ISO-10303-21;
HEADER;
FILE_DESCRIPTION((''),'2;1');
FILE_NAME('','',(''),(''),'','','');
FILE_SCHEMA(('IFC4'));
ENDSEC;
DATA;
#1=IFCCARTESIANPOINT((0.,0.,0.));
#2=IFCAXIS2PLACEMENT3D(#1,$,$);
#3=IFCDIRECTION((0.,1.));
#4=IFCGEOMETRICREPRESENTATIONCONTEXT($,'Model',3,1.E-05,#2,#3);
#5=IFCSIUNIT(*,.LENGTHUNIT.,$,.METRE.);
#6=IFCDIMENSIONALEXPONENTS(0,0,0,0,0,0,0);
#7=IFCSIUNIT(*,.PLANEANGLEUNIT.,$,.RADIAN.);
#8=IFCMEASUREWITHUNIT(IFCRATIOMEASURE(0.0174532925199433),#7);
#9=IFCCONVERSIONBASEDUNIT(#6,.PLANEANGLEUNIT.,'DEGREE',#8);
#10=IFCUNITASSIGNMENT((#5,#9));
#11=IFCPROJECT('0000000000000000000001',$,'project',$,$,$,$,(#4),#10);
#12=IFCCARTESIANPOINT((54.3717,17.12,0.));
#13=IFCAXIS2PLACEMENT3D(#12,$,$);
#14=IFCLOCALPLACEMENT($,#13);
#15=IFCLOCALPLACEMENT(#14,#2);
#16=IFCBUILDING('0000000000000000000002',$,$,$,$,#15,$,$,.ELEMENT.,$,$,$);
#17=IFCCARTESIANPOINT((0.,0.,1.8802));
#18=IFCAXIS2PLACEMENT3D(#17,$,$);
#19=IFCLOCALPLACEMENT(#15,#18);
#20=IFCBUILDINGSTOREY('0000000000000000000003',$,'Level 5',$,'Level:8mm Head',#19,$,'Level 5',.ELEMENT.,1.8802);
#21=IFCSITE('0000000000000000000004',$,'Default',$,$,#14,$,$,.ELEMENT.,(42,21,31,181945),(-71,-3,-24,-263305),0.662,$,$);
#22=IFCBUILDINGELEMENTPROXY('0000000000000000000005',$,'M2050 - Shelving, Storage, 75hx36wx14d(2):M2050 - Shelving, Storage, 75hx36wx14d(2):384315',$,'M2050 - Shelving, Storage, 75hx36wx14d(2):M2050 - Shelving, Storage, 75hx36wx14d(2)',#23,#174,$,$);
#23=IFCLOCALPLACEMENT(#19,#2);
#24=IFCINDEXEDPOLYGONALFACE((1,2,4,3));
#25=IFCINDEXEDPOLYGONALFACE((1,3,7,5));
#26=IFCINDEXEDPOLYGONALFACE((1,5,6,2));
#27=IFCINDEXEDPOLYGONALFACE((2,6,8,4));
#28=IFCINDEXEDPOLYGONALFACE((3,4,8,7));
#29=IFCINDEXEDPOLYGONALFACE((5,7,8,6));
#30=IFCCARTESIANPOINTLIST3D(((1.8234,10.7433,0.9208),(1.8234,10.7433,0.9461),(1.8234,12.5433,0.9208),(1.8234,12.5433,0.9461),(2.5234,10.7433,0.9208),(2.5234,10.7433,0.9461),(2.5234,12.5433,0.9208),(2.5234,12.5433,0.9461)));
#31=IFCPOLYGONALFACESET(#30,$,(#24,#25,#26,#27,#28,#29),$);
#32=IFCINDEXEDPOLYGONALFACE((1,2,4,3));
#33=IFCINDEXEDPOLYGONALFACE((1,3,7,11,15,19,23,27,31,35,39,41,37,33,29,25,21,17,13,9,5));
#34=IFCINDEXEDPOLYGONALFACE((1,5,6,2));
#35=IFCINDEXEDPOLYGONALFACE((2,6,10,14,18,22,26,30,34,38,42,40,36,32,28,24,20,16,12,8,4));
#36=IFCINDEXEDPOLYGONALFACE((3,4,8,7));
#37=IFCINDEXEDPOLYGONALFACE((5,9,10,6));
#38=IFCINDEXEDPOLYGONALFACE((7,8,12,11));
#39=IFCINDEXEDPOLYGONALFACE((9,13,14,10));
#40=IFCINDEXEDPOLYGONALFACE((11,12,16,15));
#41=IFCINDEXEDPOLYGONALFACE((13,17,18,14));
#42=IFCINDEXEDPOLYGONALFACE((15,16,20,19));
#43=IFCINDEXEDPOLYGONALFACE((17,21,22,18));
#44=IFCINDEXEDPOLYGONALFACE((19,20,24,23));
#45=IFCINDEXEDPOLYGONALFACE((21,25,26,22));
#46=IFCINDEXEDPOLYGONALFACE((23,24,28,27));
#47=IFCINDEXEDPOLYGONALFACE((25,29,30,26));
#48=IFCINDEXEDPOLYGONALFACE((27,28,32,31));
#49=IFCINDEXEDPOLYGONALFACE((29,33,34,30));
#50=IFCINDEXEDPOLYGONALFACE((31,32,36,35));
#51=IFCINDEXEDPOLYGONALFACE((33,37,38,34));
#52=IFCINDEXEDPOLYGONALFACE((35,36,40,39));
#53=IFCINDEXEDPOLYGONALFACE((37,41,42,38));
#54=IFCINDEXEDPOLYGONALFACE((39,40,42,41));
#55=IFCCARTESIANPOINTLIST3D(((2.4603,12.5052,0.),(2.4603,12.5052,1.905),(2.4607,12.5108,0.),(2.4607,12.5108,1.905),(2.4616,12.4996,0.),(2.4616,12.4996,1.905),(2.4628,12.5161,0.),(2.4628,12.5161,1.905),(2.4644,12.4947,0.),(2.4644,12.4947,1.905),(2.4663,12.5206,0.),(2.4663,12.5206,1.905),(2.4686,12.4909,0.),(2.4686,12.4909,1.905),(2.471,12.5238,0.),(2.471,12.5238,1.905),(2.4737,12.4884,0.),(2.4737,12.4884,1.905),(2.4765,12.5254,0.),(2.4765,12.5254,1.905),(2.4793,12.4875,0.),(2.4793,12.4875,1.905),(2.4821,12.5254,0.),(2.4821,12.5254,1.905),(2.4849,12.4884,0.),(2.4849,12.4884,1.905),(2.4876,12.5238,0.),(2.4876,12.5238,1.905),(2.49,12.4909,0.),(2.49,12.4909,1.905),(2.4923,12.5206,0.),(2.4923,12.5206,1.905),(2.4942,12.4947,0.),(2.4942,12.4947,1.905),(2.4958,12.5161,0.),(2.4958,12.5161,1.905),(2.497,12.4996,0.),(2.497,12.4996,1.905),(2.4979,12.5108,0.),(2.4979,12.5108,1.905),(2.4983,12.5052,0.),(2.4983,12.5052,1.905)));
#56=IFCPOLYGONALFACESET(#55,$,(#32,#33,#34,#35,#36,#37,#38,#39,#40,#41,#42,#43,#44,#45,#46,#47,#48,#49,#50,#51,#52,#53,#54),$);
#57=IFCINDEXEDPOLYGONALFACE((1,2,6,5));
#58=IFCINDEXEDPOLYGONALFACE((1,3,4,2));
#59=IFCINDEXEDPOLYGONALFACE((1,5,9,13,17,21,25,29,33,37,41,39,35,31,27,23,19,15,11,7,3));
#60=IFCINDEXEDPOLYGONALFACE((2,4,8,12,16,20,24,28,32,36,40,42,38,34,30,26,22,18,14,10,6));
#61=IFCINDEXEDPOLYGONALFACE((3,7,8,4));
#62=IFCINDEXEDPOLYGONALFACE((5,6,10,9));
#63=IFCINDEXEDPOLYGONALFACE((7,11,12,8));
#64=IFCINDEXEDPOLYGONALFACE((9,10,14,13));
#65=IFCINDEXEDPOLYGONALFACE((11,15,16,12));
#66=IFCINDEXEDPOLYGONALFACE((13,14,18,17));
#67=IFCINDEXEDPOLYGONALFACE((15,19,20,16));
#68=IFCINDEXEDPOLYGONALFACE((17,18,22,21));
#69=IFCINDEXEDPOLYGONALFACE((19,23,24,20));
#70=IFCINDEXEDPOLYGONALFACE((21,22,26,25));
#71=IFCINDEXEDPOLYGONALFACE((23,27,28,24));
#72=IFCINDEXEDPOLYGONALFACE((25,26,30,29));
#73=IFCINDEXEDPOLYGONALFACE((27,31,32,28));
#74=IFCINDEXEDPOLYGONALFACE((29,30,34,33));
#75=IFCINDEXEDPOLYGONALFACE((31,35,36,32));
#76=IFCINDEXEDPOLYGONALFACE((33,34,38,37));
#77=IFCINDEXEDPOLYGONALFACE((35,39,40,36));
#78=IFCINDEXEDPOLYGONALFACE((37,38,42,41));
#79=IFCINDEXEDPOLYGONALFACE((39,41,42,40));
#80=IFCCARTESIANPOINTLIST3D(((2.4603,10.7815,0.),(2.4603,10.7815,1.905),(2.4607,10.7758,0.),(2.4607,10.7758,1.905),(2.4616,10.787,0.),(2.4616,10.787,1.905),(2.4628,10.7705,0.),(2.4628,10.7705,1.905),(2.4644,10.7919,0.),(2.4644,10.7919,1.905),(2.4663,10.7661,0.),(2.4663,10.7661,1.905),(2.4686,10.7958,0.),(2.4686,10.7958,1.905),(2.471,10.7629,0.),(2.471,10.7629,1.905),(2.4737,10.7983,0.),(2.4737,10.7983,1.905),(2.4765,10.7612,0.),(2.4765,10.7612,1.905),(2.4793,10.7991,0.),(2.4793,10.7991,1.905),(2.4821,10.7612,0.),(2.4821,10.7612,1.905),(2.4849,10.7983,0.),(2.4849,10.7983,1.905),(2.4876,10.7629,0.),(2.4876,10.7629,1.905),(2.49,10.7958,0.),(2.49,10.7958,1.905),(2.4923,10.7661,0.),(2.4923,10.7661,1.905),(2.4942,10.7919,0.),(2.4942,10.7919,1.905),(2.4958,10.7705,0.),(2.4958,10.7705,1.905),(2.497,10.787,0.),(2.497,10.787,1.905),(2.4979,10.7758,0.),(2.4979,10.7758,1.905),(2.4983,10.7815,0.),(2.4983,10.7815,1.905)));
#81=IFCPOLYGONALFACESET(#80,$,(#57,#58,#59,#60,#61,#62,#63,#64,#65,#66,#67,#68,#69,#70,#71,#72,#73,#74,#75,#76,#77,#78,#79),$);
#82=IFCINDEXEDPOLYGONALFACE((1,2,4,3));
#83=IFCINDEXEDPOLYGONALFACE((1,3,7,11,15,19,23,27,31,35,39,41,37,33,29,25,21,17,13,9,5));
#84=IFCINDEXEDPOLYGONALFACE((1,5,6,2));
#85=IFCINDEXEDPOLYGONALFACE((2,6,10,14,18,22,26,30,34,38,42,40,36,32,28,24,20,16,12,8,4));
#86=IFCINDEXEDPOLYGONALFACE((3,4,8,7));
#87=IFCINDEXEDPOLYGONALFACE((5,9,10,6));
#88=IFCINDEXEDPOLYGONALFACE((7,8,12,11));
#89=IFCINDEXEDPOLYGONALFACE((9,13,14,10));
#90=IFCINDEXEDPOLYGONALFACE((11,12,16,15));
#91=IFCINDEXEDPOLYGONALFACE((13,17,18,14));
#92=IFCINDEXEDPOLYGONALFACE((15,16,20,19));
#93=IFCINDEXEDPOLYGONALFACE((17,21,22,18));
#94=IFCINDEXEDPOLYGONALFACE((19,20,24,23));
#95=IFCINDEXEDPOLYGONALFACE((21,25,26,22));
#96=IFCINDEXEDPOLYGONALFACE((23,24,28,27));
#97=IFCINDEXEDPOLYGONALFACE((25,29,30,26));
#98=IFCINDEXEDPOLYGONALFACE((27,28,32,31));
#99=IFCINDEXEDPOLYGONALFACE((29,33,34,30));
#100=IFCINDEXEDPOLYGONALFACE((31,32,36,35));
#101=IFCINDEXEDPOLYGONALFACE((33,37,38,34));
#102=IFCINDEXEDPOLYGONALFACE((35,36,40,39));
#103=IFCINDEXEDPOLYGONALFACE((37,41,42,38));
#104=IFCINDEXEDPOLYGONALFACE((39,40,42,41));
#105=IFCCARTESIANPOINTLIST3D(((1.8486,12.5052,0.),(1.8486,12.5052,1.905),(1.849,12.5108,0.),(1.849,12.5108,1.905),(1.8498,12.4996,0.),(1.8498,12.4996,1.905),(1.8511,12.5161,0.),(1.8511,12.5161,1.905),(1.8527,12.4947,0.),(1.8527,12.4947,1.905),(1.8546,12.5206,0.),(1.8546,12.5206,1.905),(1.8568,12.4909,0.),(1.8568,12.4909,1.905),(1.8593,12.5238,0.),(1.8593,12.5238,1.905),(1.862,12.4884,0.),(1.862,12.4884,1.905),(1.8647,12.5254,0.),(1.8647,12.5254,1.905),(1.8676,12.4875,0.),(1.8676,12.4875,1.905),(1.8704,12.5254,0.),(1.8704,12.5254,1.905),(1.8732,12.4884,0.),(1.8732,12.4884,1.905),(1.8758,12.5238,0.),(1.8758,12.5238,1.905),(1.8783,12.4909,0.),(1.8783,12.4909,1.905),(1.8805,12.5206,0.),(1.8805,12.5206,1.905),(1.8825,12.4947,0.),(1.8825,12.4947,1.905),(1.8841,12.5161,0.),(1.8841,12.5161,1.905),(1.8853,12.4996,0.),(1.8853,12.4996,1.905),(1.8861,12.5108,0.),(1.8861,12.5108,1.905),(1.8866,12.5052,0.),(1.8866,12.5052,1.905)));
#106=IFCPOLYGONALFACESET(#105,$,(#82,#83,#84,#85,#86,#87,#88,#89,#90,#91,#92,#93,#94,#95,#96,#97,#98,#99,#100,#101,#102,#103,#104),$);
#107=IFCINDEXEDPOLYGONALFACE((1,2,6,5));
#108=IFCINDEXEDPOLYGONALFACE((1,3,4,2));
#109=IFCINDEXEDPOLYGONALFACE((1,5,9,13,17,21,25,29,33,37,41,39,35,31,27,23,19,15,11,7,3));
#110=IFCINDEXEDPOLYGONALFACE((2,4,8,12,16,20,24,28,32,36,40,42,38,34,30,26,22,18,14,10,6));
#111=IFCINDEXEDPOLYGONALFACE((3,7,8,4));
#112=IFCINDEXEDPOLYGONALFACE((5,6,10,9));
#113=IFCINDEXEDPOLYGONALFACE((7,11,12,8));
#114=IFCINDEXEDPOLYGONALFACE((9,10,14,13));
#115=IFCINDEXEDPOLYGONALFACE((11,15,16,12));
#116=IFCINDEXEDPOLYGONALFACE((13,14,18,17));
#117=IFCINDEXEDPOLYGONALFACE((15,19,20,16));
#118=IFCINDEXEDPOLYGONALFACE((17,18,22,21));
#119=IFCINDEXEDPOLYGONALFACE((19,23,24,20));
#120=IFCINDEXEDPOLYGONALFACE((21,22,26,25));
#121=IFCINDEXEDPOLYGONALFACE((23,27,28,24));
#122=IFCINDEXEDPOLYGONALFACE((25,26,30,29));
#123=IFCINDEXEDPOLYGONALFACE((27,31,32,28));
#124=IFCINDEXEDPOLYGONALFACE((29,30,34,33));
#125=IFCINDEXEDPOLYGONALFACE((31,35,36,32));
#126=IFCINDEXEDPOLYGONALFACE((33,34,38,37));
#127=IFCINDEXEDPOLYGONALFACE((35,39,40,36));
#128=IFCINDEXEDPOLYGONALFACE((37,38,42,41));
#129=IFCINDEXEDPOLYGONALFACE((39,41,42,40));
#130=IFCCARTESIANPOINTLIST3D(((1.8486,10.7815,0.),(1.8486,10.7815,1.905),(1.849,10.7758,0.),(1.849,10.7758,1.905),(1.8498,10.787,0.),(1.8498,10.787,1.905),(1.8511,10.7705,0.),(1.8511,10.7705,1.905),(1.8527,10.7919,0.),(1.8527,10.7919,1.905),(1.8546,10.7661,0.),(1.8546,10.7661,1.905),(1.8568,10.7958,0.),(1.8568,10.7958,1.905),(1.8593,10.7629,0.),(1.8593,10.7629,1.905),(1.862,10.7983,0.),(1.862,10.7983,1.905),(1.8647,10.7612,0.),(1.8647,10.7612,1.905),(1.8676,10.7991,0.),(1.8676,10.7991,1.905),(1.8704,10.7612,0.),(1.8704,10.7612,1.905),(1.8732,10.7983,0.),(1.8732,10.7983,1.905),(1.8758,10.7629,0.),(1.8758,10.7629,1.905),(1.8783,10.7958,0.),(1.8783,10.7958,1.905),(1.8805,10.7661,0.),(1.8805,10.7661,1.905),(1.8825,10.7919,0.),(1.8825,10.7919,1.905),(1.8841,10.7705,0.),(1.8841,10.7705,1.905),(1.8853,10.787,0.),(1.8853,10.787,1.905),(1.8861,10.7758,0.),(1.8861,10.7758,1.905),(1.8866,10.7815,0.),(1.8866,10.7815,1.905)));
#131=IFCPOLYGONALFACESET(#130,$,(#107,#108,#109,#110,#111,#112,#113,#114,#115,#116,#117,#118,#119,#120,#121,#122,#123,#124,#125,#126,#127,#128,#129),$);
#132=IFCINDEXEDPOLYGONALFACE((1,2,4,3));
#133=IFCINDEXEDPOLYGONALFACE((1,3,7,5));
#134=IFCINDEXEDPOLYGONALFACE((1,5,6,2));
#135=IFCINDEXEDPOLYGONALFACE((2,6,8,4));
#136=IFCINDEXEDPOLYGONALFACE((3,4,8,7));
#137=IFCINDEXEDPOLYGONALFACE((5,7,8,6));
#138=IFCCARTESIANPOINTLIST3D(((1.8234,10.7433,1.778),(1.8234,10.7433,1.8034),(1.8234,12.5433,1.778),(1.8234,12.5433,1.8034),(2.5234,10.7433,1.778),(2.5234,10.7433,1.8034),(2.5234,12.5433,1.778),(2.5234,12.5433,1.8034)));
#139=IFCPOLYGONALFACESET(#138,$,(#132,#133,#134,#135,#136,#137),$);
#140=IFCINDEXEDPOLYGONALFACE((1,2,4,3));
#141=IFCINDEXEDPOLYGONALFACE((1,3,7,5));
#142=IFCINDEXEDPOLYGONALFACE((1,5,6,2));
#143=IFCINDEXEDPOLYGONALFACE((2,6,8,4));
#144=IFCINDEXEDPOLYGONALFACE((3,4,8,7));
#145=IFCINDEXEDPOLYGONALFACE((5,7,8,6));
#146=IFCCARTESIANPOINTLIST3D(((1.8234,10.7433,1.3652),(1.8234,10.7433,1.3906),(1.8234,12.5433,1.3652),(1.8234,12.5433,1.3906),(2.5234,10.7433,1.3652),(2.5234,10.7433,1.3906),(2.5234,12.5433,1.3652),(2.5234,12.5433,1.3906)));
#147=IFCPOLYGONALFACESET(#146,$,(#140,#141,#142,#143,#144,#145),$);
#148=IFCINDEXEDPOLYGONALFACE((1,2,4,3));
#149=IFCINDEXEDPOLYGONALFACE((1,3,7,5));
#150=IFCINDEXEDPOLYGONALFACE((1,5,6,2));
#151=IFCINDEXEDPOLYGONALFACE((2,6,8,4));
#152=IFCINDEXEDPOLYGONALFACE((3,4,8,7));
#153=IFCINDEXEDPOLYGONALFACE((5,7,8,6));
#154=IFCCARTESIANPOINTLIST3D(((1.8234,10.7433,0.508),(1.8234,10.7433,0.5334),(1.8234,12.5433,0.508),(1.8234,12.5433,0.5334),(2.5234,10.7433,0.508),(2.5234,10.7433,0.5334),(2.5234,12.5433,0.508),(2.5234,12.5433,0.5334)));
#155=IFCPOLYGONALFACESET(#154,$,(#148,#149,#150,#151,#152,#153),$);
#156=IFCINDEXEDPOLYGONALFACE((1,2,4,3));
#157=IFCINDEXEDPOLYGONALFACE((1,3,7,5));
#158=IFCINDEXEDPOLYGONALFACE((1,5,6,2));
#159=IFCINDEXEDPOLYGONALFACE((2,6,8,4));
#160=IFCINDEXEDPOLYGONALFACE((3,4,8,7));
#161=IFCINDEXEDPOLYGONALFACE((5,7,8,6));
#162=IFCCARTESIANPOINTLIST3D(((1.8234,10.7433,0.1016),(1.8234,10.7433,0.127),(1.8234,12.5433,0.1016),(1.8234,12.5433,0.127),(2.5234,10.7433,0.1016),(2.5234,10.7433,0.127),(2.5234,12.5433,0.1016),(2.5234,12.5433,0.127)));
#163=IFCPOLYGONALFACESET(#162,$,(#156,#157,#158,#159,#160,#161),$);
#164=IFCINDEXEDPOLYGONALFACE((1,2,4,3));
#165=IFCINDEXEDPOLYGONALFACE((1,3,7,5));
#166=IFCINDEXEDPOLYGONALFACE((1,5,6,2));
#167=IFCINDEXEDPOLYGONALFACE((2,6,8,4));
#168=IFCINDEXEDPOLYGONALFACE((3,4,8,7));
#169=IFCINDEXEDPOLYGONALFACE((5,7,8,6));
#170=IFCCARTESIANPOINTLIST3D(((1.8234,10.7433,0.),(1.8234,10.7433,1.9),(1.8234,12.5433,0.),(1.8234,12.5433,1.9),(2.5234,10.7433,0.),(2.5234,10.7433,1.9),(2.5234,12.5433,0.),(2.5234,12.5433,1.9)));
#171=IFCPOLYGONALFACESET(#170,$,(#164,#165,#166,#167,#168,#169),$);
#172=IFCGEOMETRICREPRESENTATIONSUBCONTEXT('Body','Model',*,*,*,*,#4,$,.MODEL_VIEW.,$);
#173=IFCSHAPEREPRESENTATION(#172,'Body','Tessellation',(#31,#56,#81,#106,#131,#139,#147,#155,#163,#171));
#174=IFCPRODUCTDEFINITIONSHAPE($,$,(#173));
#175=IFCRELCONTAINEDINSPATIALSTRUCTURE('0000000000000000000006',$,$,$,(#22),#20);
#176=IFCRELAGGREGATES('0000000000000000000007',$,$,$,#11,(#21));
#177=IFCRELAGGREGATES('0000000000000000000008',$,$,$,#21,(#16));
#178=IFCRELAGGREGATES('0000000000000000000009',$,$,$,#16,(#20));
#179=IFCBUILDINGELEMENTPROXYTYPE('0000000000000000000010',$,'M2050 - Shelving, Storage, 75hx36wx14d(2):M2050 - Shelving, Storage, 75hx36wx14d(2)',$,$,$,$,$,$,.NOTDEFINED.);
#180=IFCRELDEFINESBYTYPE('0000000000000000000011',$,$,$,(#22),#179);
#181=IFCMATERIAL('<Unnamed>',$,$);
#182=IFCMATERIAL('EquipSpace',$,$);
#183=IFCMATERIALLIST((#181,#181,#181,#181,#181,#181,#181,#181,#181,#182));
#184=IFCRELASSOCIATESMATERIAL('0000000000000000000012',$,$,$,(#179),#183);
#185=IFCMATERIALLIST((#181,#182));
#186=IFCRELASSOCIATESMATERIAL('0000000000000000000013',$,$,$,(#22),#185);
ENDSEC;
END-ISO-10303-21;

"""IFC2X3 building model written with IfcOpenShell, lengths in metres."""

from ifc_helpers import new_model, entity, si_unit, converted_unit, direction, frame, frame_2d, origin, origin_2d_with_axis, place, context, subcontext, project, spatial, rectangle, circle, extrude, source, transform, mapped, material, material_list, type_object, type_shapes, element, save


model = new_model("IFC2X3")

# Units and contexts
model_context = context("Model", 3, precision=1e-05, world=origin(), true_north=direction((0.0, 1.0)))
body_context = subcontext(model_context, "Body", "Model", "MODEL_VIEW")
ifc_project = project(units=[si_unit("LENGTHUNIT", "METRE"), converted_unit("PLANEANGLEUNIT", "DEGREE", entity("IfcRatioMeasure", 0.0174532925199433), si_unit("PLANEANGLEUNIT", "RADIAN"), dimensions=[0, 0, 0, 0, 0, 0, 0])], contexts=[model_context])

# Site, building, storey
site_placement = place(None, frame((54.3717, 17.12, 0.0)))
site = spatial("IfcSite", under=ifc_project, at=site_placement, Name="Default", CompositionType="ELEMENT", RefLatitude=(42, 21, 31, 181945), RefLongitude=(-71, -3, -24, -263305), RefElevation=0.662)
building_placement = place(site_placement, origin())
building = spatial("IfcBuilding", under=site, at=building_placement, CompositionType="ELEMENT")
storey_placement = place(building_placement, frame((0.0, 0.0, 1.8802)))
storey = spatial("IfcBuildingStorey", under=building, at=storey_placement, Name="Level 5", ObjectType="Level:8mm Head", LongName="Level 5", CompositionType="ELEMENT", Elevation=1.8802)

# Building element proxy
ifc_material_1 = material(Name="<Unnamed>")
ifc_material_2 = material(Name="EquipSpace")
ifc_material_list_1 = material_list([ifc_material_1, ifc_material_1, ifc_material_1, ifc_material_1, ifc_material_1, ifc_material_1, ifc_material_1, ifc_material_1, ifc_material_1, ifc_material_2])
building_element_proxy_type = type_object("IfcBuildingElementProxyType", Name="M2050 - Shelving, Storage, 75hx36wx14d(2):M2050 - Shelving, Storage, 75hx36wx14d(2)", PredefinedType="NOTDEFINED", material=ifc_material_list_1)
shared_shape = source(origin(), body_context, "Body", "SweptSolid", [
    extrude(rectangle(XDim=1.8, YDim=0.7, at=origin_2d_with_axis()), frame((0.0, 0.0, 0.9207), z_axis=(0.0, 0.0, 1.0), x_axis=(-1.0, 0.0, 0.0)), (0.0, 0.0, 1.0), 0.0254),
    extrude(circle(Radius=0.0191, at=origin_2d_with_axis()), frame((0.8633, -0.3059, 0.0), z_axis=(0.0, 0.0, 1.0), x_axis=(-1.0, 0.0, 0.0)), (0.0, 0.0, 1.0), 1.905),
    extrude(circle(Radius=0.0191, at=origin_2d_with_axis()), frame((-0.8633, -0.3059, 0.0)), (0.0, 0.0, 1.0), 1.905),
    extrude(circle(Radius=0.0191, at=origin_2d_with_axis()), frame((0.8633, 0.3059, 0.0), z_axis=(0.0, 0.0, 1.0), x_axis=(-1.0, 0.0, 0.0)), (0.0, 0.0, 1.0), 1.905),
    extrude(circle(Radius=0.0191, at=origin_2d_with_axis()), frame((-0.8633, 0.3059, 0.0)), (0.0, 0.0, 1.0), 1.905),
    extrude(rectangle(XDim=1.8, YDim=0.7, at=origin_2d_with_axis()), frame((0.0, 0.0, 1.778), z_axis=(0.0, 0.0, 1.0), x_axis=(-1.0, 0.0, 0.0)), (0.0, 0.0, 1.0), 0.0254),
    extrude(rectangle(XDim=1.8, YDim=0.7, at=origin_2d_with_axis()), frame((0.0, 0.0, 1.3653), z_axis=(0.0, 0.0, 1.0), x_axis=(-1.0, 0.0, 0.0)), (0.0, 0.0, 1.0), 0.0254),
    extrude(rectangle(XDim=1.8, YDim=0.7, at=origin_2d_with_axis()), frame((0.0, 0.0, 0.508), z_axis=(0.0, 0.0, 1.0), x_axis=(-1.0, 0.0, 0.0)), (0.0, 0.0, 1.0), 0.0254),
    extrude(rectangle(XDim=1.8, YDim=0.7, at=origin_2d_with_axis()), frame((0.0, 0.0, 0.1016), z_axis=(0.0, 0.0, 1.0), x_axis=(-1.0, 0.0, 0.0)), (0.0, 0.0, 1.0), 0.0254),
    extrude(rectangle(XDim=0.7, YDim=1.8, at=frame_2d((0.0, 0.18), x_axis=(1.0, 0.0))), frame((-0.18, 0.0, 0.0), z_axis=(0.0, 0.0, 1.0), x_axis=(0.0, -1.0, 0.0)), (0.0, 0.0, 1.0), 1.9),
])
type_shapes(building_element_proxy_type, [shared_shape])
ifc_material_list_2 = material_list([ifc_material_1, ifc_material_2])
proxy_1_placement = place(storey_placement, frame((2.1734, 11.6433, 0.0), z_axis=(0.0, 0.0, 1.0), x_axis=(0.0, 1.0, 0.0)))
element("IfcBuildingElementProxy", 1, at=proxy_1_placement, inside=storey, type_object=building_element_proxy_type, material=ifc_material_list_2, Name="M2050 - Shelving, Storage, 75hx36wx14d(2):M2050 - Shelving, Storage, 75hx36wx14d(2):384315", ObjectType="M2050 - Shelving, Storage, 75hx36wx14d(2):M2050 - Shelving, Storage, 75hx36wx14d(2)", context=body_context, shape_type="MappedRepresentation", body=[
    mapped(shared_shape, transform((0.0, 0.0, 0.0), scale=1.0)),
])

save(model, "model.ifc")
